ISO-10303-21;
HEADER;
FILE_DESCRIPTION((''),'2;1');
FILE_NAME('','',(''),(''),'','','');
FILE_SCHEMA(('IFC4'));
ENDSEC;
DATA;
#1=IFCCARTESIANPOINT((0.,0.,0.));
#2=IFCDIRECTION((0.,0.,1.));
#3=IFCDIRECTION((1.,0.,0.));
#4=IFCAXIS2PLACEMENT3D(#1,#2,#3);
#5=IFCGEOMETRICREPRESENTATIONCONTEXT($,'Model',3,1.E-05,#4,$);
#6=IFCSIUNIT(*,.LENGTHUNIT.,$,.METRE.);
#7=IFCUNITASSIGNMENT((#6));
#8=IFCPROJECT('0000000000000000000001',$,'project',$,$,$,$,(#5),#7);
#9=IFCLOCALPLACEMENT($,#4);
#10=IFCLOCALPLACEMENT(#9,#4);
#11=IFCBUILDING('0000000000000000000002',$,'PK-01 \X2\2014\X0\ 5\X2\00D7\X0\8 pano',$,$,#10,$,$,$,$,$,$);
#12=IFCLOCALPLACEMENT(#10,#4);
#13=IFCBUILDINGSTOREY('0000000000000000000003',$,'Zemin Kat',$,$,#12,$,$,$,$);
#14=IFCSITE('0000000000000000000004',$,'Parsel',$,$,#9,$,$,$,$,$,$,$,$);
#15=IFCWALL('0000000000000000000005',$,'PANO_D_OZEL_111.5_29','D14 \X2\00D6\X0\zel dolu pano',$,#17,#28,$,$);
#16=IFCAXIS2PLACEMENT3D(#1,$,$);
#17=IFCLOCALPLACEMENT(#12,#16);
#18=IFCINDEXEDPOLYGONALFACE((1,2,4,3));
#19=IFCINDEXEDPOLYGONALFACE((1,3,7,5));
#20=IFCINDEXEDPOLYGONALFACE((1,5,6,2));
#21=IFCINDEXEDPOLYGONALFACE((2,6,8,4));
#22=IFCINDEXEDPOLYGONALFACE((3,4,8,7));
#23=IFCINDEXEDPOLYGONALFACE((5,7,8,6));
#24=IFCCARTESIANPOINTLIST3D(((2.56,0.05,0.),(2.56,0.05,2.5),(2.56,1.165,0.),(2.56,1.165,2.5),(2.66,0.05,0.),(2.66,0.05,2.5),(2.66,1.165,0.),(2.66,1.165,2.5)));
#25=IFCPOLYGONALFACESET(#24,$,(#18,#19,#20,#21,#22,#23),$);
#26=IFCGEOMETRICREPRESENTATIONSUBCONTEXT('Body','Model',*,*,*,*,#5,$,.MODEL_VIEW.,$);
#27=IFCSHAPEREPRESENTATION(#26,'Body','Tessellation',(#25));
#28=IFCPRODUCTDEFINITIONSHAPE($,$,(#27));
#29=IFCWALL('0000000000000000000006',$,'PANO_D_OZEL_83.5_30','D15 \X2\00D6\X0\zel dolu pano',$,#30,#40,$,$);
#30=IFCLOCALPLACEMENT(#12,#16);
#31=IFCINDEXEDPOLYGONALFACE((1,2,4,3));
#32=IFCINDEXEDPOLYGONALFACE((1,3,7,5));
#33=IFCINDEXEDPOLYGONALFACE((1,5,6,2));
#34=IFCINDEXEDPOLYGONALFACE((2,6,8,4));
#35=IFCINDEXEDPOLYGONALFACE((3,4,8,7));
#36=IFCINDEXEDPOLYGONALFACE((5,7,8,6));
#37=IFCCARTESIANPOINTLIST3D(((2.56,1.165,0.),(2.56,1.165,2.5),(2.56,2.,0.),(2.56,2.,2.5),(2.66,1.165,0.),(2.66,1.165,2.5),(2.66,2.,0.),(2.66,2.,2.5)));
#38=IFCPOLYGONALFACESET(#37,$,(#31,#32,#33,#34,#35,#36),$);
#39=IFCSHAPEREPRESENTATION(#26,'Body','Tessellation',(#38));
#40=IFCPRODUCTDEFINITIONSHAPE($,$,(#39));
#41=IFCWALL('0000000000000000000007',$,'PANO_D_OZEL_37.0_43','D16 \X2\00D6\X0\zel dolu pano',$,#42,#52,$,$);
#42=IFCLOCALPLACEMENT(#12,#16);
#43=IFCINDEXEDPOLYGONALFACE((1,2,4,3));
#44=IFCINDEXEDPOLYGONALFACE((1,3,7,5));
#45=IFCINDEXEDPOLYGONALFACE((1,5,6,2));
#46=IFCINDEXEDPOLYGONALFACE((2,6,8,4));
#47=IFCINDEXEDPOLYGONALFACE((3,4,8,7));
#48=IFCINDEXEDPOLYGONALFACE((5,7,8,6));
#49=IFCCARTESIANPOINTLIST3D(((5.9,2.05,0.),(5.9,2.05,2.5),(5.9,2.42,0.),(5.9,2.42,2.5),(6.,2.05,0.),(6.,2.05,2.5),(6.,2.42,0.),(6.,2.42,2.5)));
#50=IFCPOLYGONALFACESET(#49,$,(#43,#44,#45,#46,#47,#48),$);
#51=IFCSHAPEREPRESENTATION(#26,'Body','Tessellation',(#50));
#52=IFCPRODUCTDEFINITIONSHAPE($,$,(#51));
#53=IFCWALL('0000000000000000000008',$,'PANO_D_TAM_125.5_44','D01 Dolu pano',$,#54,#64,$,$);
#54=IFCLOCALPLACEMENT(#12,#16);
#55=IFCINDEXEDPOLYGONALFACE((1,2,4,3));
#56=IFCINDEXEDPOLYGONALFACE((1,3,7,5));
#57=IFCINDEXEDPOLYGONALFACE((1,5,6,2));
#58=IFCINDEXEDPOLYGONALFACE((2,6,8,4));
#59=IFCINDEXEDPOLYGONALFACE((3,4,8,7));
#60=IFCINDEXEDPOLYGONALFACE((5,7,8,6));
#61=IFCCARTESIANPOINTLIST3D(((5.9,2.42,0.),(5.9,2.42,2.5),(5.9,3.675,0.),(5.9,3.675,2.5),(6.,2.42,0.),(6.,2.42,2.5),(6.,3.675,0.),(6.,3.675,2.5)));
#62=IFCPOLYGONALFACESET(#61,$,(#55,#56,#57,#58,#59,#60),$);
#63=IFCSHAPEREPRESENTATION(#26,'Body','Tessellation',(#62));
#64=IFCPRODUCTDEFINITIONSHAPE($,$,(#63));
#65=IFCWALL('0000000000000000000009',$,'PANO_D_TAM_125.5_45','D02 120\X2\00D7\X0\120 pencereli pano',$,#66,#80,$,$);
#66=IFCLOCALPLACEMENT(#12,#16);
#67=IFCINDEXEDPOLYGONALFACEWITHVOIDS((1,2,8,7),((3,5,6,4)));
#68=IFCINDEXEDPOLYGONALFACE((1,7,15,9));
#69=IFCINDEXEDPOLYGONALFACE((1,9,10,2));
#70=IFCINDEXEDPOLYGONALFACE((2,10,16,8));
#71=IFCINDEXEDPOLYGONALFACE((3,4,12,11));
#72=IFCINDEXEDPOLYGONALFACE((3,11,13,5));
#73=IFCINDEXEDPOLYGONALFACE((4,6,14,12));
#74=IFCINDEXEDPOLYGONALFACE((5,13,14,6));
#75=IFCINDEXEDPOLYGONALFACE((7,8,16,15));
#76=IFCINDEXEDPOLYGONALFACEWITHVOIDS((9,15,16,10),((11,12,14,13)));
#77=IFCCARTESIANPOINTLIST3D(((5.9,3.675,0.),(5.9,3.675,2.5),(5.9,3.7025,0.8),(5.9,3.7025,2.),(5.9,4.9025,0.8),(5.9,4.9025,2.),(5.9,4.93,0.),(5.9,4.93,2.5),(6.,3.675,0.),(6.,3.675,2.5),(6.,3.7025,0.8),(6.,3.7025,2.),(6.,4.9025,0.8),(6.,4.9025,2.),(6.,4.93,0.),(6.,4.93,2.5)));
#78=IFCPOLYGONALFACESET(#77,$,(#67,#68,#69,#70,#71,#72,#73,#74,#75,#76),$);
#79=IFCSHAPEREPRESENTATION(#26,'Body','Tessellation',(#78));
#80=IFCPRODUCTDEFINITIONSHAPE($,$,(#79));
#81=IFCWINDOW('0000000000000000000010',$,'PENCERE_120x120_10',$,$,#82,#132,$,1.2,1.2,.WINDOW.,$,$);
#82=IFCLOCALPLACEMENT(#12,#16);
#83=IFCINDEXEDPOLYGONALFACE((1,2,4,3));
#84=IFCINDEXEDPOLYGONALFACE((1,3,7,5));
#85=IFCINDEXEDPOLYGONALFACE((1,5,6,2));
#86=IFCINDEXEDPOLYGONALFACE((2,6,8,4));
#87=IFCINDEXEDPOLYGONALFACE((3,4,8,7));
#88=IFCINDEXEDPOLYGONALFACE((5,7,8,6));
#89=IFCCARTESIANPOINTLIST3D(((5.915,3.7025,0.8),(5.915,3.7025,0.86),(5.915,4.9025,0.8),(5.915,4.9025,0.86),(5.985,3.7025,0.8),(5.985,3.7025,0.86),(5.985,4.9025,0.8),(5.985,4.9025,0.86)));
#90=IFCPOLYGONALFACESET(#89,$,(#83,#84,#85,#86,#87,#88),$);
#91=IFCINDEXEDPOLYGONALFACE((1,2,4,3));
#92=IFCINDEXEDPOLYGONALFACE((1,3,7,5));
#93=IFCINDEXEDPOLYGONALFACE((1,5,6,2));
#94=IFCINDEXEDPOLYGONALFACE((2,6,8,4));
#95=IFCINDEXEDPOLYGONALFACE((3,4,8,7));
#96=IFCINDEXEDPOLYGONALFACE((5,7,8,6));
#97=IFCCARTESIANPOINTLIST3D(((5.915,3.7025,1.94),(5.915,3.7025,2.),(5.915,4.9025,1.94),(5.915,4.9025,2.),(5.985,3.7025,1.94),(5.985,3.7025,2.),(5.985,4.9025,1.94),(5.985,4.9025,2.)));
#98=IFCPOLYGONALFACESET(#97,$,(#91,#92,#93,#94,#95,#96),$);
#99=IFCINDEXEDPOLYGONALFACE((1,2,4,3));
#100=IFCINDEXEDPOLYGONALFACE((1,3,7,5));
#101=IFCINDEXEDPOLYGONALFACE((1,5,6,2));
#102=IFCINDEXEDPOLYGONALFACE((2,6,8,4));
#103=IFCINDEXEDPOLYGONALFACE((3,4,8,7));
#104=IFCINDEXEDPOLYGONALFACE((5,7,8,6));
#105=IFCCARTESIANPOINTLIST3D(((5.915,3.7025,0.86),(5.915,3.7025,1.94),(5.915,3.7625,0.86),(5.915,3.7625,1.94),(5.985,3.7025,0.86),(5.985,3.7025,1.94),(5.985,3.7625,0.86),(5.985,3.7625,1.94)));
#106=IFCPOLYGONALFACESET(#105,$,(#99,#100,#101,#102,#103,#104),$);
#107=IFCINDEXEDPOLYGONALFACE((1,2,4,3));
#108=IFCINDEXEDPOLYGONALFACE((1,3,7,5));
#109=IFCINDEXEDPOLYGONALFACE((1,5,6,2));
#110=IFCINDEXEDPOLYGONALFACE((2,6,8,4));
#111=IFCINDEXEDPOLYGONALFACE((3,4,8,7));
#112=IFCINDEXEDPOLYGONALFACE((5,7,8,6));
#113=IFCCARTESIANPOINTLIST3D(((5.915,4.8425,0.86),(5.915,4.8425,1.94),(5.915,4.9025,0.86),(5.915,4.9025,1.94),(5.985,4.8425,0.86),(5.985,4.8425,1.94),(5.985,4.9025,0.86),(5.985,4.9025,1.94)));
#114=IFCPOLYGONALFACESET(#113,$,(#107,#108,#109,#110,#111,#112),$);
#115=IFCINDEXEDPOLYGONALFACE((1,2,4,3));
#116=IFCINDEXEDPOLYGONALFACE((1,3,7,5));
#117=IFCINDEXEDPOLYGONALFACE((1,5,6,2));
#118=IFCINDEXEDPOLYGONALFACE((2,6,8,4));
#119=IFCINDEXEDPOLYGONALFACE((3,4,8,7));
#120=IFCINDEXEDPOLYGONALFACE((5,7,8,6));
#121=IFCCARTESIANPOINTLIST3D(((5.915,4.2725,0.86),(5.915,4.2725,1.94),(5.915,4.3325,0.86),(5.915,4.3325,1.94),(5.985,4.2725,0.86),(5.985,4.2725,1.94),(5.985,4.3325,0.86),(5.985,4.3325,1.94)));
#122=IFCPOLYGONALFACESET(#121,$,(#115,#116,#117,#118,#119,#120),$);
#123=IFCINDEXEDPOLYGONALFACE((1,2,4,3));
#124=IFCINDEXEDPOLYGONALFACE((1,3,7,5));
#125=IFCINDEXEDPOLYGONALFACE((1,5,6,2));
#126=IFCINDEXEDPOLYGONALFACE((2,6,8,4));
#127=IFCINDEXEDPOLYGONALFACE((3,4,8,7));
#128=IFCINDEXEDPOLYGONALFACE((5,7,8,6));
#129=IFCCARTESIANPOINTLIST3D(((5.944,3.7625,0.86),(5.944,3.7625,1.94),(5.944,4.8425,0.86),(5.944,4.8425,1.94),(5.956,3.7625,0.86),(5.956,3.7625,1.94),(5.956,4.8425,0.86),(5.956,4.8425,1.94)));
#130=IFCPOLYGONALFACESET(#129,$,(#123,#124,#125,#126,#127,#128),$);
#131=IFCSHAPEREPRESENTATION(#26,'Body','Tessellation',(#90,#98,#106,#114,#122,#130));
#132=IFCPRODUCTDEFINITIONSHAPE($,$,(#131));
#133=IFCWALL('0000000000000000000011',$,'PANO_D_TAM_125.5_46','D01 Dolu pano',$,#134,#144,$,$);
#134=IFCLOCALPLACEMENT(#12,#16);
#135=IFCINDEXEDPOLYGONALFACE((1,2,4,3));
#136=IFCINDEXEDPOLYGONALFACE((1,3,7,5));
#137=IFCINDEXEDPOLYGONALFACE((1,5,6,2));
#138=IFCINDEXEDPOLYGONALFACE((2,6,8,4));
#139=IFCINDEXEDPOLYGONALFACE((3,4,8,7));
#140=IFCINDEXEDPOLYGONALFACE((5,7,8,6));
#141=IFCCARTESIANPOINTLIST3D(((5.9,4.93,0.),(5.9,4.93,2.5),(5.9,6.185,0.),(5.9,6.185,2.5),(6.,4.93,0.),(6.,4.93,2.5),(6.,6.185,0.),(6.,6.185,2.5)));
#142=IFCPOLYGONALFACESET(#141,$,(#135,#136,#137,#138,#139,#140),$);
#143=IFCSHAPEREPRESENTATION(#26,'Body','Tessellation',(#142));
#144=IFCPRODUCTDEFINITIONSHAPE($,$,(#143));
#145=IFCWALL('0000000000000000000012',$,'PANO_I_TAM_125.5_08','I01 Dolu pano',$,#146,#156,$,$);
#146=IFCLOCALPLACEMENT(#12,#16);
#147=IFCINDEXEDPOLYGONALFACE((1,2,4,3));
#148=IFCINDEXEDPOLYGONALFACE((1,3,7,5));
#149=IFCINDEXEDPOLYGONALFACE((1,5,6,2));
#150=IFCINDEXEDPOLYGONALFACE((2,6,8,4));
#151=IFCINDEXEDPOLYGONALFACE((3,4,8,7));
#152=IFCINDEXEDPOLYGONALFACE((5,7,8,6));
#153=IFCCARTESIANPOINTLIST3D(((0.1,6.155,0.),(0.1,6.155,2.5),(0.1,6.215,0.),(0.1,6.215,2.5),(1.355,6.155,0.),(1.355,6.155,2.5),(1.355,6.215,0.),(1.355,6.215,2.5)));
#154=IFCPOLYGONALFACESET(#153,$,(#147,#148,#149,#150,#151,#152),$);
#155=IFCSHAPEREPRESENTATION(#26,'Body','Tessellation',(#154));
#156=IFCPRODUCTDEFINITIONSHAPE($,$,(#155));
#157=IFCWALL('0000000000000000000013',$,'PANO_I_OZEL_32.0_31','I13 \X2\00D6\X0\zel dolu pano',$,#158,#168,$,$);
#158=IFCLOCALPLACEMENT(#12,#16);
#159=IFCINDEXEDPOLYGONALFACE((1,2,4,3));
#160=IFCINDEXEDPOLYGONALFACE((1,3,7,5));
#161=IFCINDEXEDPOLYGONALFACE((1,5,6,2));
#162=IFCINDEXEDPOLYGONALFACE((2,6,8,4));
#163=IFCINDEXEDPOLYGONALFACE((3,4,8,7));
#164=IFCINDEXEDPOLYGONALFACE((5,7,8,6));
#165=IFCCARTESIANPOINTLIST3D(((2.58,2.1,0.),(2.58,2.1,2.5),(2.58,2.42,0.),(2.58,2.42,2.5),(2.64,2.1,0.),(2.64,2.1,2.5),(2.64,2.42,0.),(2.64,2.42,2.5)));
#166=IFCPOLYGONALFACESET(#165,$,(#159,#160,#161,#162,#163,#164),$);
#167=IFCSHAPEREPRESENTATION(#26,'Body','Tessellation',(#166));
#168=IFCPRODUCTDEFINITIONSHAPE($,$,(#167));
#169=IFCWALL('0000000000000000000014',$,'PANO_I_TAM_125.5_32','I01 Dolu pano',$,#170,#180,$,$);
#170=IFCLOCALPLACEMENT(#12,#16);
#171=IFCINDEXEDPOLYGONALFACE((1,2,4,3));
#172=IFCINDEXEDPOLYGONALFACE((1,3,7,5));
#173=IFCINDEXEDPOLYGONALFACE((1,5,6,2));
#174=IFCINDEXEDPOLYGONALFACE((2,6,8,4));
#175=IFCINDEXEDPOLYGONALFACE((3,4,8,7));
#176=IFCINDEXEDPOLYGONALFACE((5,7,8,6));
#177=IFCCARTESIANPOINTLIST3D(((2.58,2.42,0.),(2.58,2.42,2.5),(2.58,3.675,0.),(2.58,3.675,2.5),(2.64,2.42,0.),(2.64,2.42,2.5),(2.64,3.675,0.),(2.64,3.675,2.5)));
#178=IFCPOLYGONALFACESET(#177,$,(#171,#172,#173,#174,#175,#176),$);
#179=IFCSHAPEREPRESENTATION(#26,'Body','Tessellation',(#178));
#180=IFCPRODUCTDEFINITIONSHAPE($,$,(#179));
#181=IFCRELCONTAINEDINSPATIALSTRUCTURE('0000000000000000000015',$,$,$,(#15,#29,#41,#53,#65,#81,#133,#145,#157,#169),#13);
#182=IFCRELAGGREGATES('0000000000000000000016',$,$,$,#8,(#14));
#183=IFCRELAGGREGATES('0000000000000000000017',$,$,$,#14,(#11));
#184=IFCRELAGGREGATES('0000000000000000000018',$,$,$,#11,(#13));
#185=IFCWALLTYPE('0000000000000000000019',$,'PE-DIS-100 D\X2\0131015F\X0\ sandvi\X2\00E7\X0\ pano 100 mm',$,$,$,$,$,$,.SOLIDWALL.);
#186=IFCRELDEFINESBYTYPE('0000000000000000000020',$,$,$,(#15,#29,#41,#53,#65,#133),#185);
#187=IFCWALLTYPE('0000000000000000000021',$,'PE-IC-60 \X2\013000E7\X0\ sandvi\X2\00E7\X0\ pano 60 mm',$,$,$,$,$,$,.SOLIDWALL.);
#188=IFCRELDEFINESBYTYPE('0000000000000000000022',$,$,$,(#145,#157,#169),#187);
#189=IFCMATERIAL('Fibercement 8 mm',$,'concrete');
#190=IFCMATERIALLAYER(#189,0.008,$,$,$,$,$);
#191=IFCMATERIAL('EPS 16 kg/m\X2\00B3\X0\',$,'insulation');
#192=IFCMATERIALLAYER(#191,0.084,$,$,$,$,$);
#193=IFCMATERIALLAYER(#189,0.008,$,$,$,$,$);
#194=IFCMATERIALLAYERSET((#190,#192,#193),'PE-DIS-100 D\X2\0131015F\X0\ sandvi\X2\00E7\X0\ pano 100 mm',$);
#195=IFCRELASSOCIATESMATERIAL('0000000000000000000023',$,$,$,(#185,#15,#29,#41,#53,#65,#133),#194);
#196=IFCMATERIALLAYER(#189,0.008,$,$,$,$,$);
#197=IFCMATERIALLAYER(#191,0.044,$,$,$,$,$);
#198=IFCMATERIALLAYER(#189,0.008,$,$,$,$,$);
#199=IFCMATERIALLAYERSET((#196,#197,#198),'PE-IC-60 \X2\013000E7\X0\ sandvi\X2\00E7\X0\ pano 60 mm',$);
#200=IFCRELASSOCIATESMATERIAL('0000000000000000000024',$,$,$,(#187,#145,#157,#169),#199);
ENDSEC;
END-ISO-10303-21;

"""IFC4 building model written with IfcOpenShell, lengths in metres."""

from ifc_helpers import new_model, si_unit, frame, origin_with_axes, place, context, subcontext, project, spatial, line, indexed_curve, outline, extrude, material, layer, layer_set, layer_usage, type_object, element, fill, save


model = new_model("IFC4")

# Units and contexts
model_context = context("Model", 3, precision=1e-05, world=origin_with_axes())
body_context = subcontext(model_context, "Body", "Model", "MODEL_VIEW")
ifc_project = project(units=[si_unit("LENGTHUNIT", "METRE")], contexts=[model_context])

# Site, building, storey
site_placement = place(None, origin_with_axes())
site = spatial("IfcSite", under=ifc_project, at=site_placement, Name="Parsel")
building_placement = place(site_placement, origin_with_axes())
building = spatial("IfcBuilding", under=site, at=building_placement, Name="PK-01 — 5×8 pano")
storey_placement = place(building_placement, origin_with_axes())
storey = spatial("IfcBuildingStorey", under=building, at=storey_placement, Name="Zemin Kat")

# Shared definitions
ifc_material_1 = material(Name="Fibercement 8 mm", Category="concrete")
ifc_layer_1 = layer(ifc_material_1, 0.008)
ifc_material_2 = material(Name="EPS 16 kg/m³", Category="insulation")
ifc_layer_2 = layer(ifc_material_2, 0.084)
ifc_layer_3 = layer(ifc_material_1, 0.008)
ifc_layer_set_1 = layer_set([ifc_layer_1, ifc_layer_2, ifc_layer_3], Name="PE-DIS-100 Dış sandviç pano 100 mm")
wall_type_1 = type_object("IfcWallType", Name="PE-DIS-100 Dış sandviç pano 100 mm", PredefinedType="SOLIDWALL", material=ifc_layer_set_1)

# Walls
ifc_layer_usage_1 = layer_usage(ifc_layer_set_1, "AXIS2", "POSITIVE", 0.0)
wall_1_placement = place(storey_placement, frame((2.66, 0.05, 0.0), z_axis=(0.0, 0.0, 1.0), x_axis=(0.0, 1.0, 0.0)))
element("IfcWall", 1, at=wall_1_placement, inside=storey, type_object=wall_type_1, material=ifc_layer_usage_1, Name="PANO_D_OZEL_111.5_29", Description="D14 Özel dolu pano", context=body_context, shape_type="SweptSolid", body=[
    extrude(outline(indexed_curve([(0.0, 0.0), (1.115, 0.0), (1.115, 0.1), (0.0, 0.1)], segments=[line(1, 2, 3, 4, 1)])), origin_with_axes(), (0.0, 0.0, 1.0), 2.5),
])
ifc_layer_usage_2 = layer_usage(ifc_layer_set_1, "AXIS2", "POSITIVE", 0.0)
wall_2_placement = place(storey_placement, frame((2.66, 1.165, 0.0), z_axis=(0.0, 0.0, 1.0), x_axis=(0.0, 1.0, 0.0)))
element("IfcWall", 2, at=wall_2_placement, inside=storey, type_object=wall_type_1, material=ifc_layer_usage_2, Name="PANO_D_OZEL_83.5_30", Description="D15 Özel dolu pano", context=body_context, shape_type="SweptSolid", body=[
    extrude(outline(indexed_curve([(0.0, 0.0), (0.835, 0.0), (0.835, 0.1), (0.0, 0.1)], segments=[line(1, 2, 3, 4, 1)])), origin_with_axes(), (0.0, 0.0, 1.0), 2.5),
])
ifc_layer_usage_3 = layer_usage(ifc_layer_set_1, "AXIS2", "POSITIVE", 0.0)
wall_3_placement = place(storey_placement, frame((6.0, 2.05, 0.0), z_axis=(0.0, 0.0, 1.0), x_axis=(0.0, 1.0, 0.0)))
element("IfcWall", 3, at=wall_3_placement, inside=storey, type_object=wall_type_1, material=ifc_layer_usage_3, Name="PANO_D_OZEL_37.0_43", Description="D16 Özel dolu pano", context=body_context, shape_type="SweptSolid", body=[
    extrude(outline(indexed_curve([(0.0, 0.0), (0.37, 0.0), (0.37, 0.1), (0.0, 0.1)], segments=[line(1, 2, 3, 4, 1)])), origin_with_axes(), (0.0, 0.0, 1.0), 2.5),
])
ifc_layer_usage_4 = layer_usage(ifc_layer_set_1, "AXIS2", "POSITIVE", 0.0)
wall_4_placement = place(storey_placement, frame((6.0, 2.42, 0.0), z_axis=(0.0, 0.0, 1.0), x_axis=(0.0, 1.0, 0.0)))
element("IfcWall", 4, at=wall_4_placement, inside=storey, type_object=wall_type_1, material=ifc_layer_usage_4, Name="PANO_D_TAM_125.5_44", Description="D01 Dolu pano", context=body_context, shape_type="SweptSolid", body=[
    extrude(outline(indexed_curve([(0.0, 0.0), (1.255, 0.0), (1.255, 0.1), (0.0, 0.1)], segments=[line(1, 2, 3, 4, 1)])), origin_with_axes(), (0.0, 0.0, 1.0), 2.5),
])

# Wall, opening, window
ifc_layer_usage_5 = layer_usage(ifc_layer_set_1, "AXIS2", "POSITIVE", 0.0)
wall_5_placement = place(storey_placement, frame((6.0, 3.675, 0.0), z_axis=(0.0, 0.0, 1.0), x_axis=(0.0, 1.0, 0.0)))
wall_5 = element("IfcWall", 5, at=wall_5_placement, inside=storey, type_object=wall_type_1, material=ifc_layer_usage_5, Name="PANO_D_TAM_125.5_45", Description="D02 120×120 pencereli pano", context=body_context, shape_type="SweptSolid", body=[
    extrude(outline(indexed_curve([(0.0, 0.0), (1.255, 0.0), (1.255, 0.1), (0.0, 0.1)], segments=[line(1, 2, 3, 4, 1)])), origin_with_axes(), (0.0, 0.0, 1.0), 2.5),
])
opening_1_placement = place(wall_5_placement, origin_with_axes())
opening_1 = element("IfcOpeningElement", 6, at=opening_1_placement, cuts=wall_5, PredefinedType="OPENING", context=body_context, shape_type="SweptSolid", body=[
    extrude(outline(indexed_curve([(0.0, 0.0), (1.2, 0.0), (1.2, 0.14), (0.0, 0.14)], segments=[line(1, 2, 3, 4, 1)])), frame((0.0275, -0.02, 0.8), z_axis=(0.0, 0.0, 1.0), x_axis=(1.0, 0.0, 0.0)), (0.0, 0.0, 1.0), 1.2),
])
window_1_placement = place(storey_placement, frame((6.0, 3.675, 0.0), z_axis=(0.0, 0.0, 1.0), x_axis=(0.0, 1.0, 0.0)))
window_1 = element("IfcWindow", 7, at=window_1_placement, inside=storey, Name="PENCERE_120x120_10", OverallHeight=1.2, OverallWidth=1.2, PredefinedType="WINDOW", context=body_context, shape_type="SweptSolid", body=[
    extrude(outline(indexed_curve([(0.0, 0.0), (1.2, 0.0), (1.2, 0.07), (0.0, 0.07)], segments=[line(1, 2, 3, 4, 1)])), frame((0.0275, 0.015, 0.8), z_axis=(0.0, 0.0, 1.0), x_axis=(1.0, 0.0, 0.0)), (0.0, 0.0, 1.0), 0.06),
    extrude(outline(indexed_curve([(0.0, 0.0), (1.2, 0.0), (1.2, 0.07), (0.0, 0.07)], segments=[line(1, 2, 3, 4, 1)])), frame((0.0275, 0.015, 1.94), z_axis=(0.0, 0.0, 1.0), x_axis=(1.0, 0.0, 0.0)), (0.0, 0.0, 1.0), 0.06),
    extrude(outline(indexed_curve([(0.0, 0.0), (0.06, 0.0), (0.06, 0.07), (0.0, 0.07)], segments=[line(1, 2, 3, 4, 1)])), frame((0.0275, 0.015, 0.86), z_axis=(0.0, 0.0, 1.0), x_axis=(1.0, 0.0, 0.0)), (0.0, 0.0, 1.0), 1.08),
    extrude(outline(indexed_curve([(0.0, 0.0), (0.06, 0.0), (0.06, 0.07), (0.0, 0.07)], segments=[line(1, 2, 3, 4, 1)])), frame((1.1675, 0.015, 0.86), z_axis=(0.0, 0.0, 1.0), x_axis=(1.0, 0.0, 0.0)), (0.0, 0.0, 1.0), 1.08),
    extrude(outline(indexed_curve([(0.0, 0.0), (0.06, 0.0), (0.06, 0.07), (0.0, 0.07)], segments=[line(1, 2, 3, 4, 1)])), frame((0.5975, 0.015, 0.86), z_axis=(0.0, 0.0, 1.0), x_axis=(1.0, 0.0, 0.0)), (0.0, 0.0, 1.0), 1.08),
    extrude(outline(indexed_curve([(0.0, 0.0), (1.08, 0.0), (1.08, 0.012), (0.0, 0.012)], segments=[line(1, 2, 3, 4, 1)])), frame((0.0875, 0.044, 0.86), z_axis=(0.0, 0.0, 1.0), x_axis=(1.0, 0.0, 0.0)), (0.0, 0.0, 1.0), 1.08),
])
fill(opening_1, window_1)

# Walls
ifc_layer_usage_6 = layer_usage(ifc_layer_set_1, "AXIS2", "POSITIVE", 0.0)
wall_6_placement = place(storey_placement, frame((6.0, 4.93, 0.0), z_axis=(0.0, 0.0, 1.0), x_axis=(0.0, 1.0, 0.0)))
element("IfcWall", 8, at=wall_6_placement, inside=storey, type_object=wall_type_1, material=ifc_layer_usage_6, Name="PANO_D_TAM_125.5_46", Description="D01 Dolu pano", context=body_context, shape_type="SweptSolid", body=[
    extrude(outline(indexed_curve([(0.0, 0.0), (1.255, 0.0), (1.255, 0.1), (0.0, 0.1)], segments=[line(1, 2, 3, 4, 1)])), origin_with_axes(), (0.0, 0.0, 1.0), 2.5),
])
ifc_layer_4 = layer(ifc_material_1, 0.008)
ifc_layer_5 = layer(ifc_material_2, 0.044)
ifc_layer_6 = layer(ifc_material_1, 0.008)
ifc_layer_set_2 = layer_set([ifc_layer_4, ifc_layer_5, ifc_layer_6], Name="PE-IC-60 İç sandviç pano 60 mm")
ifc_layer_usage_7 = layer_usage(ifc_layer_set_2, "AXIS2", "POSITIVE", 0.0)
wall_type_2 = type_object("IfcWallType", Name="PE-IC-60 İç sandviç pano 60 mm", PredefinedType="SOLIDWALL", material=ifc_layer_set_2)
wall_7_placement = place(storey_placement, frame((0.1, 6.155, 0.0), z_axis=(0.0, 0.0, 1.0), x_axis=(1.0, 0.0, 0.0)))
element("IfcWall", 9, at=wall_7_placement, inside=storey, type_object=wall_type_2, material=ifc_layer_usage_7, Name="PANO_I_TAM_125.5_08", Description="I01 Dolu pano", context=body_context, shape_type="SweptSolid", body=[
    extrude(outline(indexed_curve([(0.0, 0.0), (1.255, 0.0), (1.255, 0.06), (0.0, 0.06)], segments=[line(1, 2, 3, 4, 1)])), origin_with_axes(), (0.0, 0.0, 1.0), 2.5),
])
ifc_layer_usage_8 = layer_usage(ifc_layer_set_2, "AXIS2", "POSITIVE", 0.0)
wall_8_placement = place(storey_placement, frame((2.64, 2.1, 0.0), z_axis=(0.0, 0.0, 1.0), x_axis=(0.0, 1.0, 0.0)))
element("IfcWall", 10, at=wall_8_placement, inside=storey, type_object=wall_type_2, material=ifc_layer_usage_8, Name="PANO_I_OZEL_32.0_31", Description="I13 Özel dolu pano", context=body_context, shape_type="SweptSolid", body=[
    extrude(outline(indexed_curve([(0.0, 0.0), (0.32, 0.0), (0.32, 0.06), (0.0, 0.06)], segments=[line(1, 2, 3, 4, 1)])), origin_with_axes(), (0.0, 0.0, 1.0), 2.5),
])
ifc_layer_usage_9 = layer_usage(ifc_layer_set_2, "AXIS2", "POSITIVE", 0.0)
wall_9_placement = place(storey_placement, frame((2.64, 2.42, 0.0), z_axis=(0.0, 0.0, 1.0), x_axis=(0.0, 1.0, 0.0)))
element("IfcWall", 11, at=wall_9_placement, inside=storey, type_object=wall_type_2, material=ifc_layer_usage_9, Name="PANO_I_TAM_125.5_32", Description="I01 Dolu pano", context=body_context, shape_type="SweptSolid", body=[
    extrude(outline(indexed_curve([(0.0, 0.0), (1.255, 0.0), (1.255, 0.06), (0.0, 0.06)], segments=[line(1, 2, 3, 4, 1)])), origin_with_axes(), (0.0, 0.0, 1.0), 2.5),
])

save(model, "model.ifc")
